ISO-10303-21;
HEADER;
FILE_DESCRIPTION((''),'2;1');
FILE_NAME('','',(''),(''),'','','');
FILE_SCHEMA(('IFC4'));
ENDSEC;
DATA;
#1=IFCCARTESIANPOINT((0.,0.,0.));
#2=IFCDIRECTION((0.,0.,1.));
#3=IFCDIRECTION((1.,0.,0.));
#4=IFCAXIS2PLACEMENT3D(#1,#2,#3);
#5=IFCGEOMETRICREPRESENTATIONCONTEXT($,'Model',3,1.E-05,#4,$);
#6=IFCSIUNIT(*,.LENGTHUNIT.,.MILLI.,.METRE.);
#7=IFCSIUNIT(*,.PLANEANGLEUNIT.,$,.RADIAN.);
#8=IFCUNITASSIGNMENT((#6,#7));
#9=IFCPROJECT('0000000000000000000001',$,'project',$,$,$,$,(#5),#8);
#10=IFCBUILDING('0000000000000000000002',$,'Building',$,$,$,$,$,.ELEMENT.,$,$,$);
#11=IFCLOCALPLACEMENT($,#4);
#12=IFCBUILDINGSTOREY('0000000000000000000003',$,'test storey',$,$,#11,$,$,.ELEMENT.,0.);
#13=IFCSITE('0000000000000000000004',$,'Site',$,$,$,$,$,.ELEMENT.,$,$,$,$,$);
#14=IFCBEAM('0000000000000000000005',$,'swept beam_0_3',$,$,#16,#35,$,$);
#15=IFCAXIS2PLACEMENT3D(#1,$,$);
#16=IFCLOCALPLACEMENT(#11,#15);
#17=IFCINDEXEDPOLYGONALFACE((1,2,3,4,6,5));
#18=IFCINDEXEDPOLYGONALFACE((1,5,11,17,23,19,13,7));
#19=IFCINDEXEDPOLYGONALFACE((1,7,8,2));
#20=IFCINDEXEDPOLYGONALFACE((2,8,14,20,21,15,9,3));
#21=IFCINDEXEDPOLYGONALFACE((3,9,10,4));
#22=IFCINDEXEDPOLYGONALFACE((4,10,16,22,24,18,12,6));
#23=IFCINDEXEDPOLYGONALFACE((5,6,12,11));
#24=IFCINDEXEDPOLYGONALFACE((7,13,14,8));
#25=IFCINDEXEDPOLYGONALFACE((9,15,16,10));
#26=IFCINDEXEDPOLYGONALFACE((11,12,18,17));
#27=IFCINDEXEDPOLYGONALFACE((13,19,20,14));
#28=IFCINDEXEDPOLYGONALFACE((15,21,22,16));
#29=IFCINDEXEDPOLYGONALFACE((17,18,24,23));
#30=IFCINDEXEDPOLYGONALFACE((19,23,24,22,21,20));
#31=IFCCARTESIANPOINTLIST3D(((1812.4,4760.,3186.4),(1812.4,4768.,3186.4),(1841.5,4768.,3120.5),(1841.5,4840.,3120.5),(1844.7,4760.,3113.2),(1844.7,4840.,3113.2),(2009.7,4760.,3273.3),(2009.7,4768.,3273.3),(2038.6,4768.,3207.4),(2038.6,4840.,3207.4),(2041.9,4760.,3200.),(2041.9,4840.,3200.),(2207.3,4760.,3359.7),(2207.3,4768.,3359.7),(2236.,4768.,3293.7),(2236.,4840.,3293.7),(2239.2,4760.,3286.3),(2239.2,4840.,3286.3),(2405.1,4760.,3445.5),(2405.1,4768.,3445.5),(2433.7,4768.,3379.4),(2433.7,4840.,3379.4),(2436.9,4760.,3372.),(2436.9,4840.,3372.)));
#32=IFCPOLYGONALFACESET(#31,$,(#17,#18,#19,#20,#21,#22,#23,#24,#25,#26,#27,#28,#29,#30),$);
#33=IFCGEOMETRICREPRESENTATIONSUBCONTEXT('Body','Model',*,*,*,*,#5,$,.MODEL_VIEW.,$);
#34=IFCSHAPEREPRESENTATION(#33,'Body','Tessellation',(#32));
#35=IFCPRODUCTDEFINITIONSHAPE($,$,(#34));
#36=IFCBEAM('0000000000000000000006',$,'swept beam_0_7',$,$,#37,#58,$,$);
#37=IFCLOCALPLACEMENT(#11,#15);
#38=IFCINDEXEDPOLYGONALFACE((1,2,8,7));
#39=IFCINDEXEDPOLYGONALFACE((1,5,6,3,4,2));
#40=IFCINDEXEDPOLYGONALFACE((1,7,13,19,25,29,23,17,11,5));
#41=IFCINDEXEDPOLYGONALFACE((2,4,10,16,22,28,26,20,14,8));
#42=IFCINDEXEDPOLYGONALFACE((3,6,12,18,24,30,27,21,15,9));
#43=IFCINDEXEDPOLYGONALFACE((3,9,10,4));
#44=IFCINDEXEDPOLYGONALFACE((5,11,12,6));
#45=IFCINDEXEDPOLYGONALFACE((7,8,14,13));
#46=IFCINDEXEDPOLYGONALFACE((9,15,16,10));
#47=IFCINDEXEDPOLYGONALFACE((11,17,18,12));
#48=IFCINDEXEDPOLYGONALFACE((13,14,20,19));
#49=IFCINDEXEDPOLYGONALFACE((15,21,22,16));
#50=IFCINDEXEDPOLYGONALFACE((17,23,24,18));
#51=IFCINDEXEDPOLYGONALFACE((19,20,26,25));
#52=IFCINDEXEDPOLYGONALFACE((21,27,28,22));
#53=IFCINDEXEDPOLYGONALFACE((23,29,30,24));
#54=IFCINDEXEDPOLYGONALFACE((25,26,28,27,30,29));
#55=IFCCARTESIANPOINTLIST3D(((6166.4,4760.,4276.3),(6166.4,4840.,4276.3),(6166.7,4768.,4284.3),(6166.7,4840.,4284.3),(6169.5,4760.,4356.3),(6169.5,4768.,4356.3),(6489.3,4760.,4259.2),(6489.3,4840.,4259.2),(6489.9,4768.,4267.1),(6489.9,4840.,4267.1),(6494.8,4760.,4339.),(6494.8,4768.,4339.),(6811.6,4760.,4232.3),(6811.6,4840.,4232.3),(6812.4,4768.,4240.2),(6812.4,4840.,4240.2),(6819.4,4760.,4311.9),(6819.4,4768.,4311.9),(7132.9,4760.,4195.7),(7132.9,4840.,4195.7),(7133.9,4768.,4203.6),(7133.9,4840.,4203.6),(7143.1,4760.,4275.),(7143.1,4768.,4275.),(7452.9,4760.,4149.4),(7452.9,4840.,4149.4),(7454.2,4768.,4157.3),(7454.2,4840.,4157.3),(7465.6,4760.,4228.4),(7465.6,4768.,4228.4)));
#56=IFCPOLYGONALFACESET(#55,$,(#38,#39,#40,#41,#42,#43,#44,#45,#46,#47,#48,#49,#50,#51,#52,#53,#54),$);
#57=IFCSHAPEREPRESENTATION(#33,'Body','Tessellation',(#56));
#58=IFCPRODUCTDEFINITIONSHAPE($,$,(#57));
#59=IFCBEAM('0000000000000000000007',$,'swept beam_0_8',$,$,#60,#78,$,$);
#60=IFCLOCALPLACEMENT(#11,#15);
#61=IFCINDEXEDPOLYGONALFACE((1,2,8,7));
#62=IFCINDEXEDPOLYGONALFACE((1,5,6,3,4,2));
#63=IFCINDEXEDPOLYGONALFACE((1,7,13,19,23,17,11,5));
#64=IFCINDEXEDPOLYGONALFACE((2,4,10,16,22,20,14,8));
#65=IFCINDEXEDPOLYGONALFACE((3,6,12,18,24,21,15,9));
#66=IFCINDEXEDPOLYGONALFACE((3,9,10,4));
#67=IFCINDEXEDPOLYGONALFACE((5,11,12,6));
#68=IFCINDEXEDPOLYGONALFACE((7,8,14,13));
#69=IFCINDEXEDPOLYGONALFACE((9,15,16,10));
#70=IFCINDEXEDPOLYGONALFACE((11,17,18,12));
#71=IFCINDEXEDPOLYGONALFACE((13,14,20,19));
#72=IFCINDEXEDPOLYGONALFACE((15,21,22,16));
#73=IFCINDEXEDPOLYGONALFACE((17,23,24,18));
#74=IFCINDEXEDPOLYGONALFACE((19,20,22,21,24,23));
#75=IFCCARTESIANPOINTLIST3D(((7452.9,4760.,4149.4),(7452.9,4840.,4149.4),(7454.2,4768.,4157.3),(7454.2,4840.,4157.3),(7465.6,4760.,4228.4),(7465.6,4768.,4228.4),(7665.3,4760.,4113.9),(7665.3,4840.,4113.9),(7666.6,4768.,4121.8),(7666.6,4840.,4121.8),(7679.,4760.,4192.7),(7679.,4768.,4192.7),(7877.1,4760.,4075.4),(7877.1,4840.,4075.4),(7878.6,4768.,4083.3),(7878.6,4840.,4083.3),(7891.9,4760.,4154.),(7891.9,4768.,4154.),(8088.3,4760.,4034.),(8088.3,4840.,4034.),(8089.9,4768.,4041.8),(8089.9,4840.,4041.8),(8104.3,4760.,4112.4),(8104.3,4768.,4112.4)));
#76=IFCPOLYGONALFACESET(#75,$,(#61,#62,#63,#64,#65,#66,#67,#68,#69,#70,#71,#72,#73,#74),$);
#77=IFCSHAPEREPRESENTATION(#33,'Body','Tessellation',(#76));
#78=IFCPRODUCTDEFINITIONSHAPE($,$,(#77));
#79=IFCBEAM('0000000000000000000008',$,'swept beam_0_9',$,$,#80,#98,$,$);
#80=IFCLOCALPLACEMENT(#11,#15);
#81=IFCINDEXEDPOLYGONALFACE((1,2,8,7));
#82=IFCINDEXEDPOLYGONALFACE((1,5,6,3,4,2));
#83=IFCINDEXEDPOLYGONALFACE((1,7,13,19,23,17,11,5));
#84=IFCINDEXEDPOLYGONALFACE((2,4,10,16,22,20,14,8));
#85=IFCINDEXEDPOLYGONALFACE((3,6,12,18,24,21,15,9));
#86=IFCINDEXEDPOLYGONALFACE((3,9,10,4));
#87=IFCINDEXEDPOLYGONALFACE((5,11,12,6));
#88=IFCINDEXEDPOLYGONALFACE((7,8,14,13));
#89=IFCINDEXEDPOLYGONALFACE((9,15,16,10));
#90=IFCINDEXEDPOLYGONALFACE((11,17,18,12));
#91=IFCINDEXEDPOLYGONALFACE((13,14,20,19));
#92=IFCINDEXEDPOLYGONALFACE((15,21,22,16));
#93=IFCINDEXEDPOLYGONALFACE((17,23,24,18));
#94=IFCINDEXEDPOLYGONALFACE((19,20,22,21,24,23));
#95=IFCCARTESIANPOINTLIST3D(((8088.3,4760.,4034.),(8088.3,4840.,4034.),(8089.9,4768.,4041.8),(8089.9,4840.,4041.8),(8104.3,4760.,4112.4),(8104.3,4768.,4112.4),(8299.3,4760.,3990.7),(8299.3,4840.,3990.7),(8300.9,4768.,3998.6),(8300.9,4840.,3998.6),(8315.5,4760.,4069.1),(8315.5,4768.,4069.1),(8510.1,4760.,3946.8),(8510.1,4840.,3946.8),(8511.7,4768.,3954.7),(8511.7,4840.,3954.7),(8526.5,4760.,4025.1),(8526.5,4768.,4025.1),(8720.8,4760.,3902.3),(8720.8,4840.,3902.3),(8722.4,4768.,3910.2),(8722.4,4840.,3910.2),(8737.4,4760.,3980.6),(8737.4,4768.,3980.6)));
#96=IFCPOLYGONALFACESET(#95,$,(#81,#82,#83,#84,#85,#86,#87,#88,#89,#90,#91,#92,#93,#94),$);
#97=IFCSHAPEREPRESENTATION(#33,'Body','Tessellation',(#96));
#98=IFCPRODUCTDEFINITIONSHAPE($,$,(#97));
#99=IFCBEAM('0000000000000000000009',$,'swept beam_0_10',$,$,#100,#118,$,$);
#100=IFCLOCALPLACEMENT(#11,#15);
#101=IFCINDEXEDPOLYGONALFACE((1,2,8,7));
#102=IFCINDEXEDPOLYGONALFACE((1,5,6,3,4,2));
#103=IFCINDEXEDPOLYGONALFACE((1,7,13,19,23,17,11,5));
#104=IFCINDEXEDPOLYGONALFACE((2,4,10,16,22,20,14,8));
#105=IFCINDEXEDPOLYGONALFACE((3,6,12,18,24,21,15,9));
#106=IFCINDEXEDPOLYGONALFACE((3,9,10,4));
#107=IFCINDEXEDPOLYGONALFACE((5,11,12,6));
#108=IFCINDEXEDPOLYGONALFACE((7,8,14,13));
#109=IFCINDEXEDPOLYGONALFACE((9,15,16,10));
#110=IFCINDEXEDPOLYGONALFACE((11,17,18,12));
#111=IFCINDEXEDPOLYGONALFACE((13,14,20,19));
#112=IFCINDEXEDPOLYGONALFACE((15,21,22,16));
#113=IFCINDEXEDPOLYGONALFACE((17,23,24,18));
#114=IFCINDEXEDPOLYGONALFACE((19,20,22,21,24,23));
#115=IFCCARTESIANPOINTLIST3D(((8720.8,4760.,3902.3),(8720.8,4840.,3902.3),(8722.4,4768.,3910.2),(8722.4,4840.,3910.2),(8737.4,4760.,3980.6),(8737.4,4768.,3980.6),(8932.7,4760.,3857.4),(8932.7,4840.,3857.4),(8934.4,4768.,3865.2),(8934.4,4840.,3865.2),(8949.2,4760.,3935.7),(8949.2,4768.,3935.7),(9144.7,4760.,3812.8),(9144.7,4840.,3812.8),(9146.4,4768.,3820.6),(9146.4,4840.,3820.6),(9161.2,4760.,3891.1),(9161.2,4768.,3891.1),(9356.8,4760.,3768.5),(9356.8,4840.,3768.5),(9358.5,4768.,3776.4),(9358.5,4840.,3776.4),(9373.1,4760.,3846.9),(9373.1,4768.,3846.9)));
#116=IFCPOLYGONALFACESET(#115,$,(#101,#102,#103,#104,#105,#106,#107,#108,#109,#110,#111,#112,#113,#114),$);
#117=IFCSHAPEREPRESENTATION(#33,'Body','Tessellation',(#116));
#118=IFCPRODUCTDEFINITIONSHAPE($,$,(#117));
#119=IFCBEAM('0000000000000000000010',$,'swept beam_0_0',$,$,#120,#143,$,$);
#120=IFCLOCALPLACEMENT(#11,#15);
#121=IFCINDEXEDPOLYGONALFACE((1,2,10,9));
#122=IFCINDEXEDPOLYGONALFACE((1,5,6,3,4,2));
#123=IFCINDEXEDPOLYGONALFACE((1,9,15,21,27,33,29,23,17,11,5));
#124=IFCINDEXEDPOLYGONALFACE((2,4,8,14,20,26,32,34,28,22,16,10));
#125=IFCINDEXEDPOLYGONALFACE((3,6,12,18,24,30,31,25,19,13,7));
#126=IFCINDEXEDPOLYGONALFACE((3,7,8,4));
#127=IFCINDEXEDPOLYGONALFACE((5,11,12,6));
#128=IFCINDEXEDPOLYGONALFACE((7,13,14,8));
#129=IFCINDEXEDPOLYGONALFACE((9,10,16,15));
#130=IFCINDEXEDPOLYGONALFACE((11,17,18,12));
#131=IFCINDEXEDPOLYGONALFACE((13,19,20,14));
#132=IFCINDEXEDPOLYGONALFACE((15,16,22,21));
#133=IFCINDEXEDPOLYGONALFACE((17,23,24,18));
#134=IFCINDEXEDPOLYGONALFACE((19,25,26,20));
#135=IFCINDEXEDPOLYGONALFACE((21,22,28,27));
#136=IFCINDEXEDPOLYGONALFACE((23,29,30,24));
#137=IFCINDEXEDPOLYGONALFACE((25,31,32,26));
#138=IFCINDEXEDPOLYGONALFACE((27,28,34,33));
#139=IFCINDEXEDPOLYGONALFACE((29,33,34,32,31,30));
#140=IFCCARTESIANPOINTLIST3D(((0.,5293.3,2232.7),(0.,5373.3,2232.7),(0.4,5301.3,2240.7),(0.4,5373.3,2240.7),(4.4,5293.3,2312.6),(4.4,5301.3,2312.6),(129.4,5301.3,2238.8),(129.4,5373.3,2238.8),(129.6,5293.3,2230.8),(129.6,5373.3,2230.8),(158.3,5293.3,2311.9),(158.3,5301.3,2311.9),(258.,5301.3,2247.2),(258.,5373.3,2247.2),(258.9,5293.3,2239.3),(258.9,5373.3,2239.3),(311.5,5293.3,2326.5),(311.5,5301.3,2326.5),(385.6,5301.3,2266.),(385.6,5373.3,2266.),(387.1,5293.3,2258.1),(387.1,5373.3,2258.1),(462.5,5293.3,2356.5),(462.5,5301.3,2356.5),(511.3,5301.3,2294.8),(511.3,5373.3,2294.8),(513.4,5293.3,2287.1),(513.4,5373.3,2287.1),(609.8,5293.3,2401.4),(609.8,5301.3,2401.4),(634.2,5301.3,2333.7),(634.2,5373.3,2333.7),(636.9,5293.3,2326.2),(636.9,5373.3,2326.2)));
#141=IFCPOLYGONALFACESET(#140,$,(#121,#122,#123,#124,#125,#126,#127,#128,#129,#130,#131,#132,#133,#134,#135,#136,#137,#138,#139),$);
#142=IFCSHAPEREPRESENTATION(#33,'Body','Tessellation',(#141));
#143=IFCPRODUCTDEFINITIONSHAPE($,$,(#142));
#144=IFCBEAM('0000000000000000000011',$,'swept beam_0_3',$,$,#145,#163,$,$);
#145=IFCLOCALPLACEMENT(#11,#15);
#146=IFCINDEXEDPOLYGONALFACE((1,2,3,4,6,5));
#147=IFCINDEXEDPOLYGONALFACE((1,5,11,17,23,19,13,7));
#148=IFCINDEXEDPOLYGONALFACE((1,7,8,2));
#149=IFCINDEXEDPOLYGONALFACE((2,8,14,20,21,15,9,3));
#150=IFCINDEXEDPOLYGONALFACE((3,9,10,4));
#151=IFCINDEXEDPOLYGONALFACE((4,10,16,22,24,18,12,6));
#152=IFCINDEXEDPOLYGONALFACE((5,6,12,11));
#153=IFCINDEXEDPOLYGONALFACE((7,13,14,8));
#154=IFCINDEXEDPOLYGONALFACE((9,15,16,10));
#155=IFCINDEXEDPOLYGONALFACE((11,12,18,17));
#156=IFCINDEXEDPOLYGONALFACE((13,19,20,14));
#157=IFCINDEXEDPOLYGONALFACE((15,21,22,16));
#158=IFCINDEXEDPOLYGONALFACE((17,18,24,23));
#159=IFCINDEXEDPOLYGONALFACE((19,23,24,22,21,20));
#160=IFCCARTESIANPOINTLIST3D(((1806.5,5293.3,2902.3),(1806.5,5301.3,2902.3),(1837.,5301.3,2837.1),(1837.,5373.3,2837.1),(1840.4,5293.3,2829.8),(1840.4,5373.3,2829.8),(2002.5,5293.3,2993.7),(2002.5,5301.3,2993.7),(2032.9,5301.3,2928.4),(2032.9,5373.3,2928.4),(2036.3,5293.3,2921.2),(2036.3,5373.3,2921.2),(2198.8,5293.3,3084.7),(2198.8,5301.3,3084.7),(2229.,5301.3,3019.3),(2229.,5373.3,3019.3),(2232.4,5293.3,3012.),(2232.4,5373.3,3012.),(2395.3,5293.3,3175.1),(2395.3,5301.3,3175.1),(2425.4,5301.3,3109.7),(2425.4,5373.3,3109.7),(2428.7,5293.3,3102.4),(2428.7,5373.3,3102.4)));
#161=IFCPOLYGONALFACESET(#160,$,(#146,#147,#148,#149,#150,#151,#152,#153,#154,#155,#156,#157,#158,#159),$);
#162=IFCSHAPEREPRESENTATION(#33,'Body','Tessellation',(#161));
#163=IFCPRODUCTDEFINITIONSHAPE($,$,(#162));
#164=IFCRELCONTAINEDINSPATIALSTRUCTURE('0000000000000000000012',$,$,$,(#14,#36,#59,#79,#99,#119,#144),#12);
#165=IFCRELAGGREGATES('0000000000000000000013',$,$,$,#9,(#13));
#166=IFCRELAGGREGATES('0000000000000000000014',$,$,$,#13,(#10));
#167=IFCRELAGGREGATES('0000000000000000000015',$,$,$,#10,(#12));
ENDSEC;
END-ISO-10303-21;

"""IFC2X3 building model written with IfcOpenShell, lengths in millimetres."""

from ifc_helpers import new_model, entity, si_unit, origin_with_axes, place, context, subcontext, project, spatial, element, save


model = new_model("IFC2X3")

# Units and contexts
model_context = context("Model", 3, precision=1e-05, world=origin_with_axes())
body_context = subcontext(model_context, "Body", "Model", "MODEL_VIEW")
ifc_project = project(units=[si_unit("LENGTHUNIT", "METRE", prefix="MILLI"), si_unit("PLANEANGLEUNIT", "RADIAN")], contexts=[model_context])

# Site, building, storey
site = spatial("IfcSite", under=ifc_project, Name="Site", CompositionType="ELEMENT")
building = spatial("IfcBuilding", under=site, Name="Building", CompositionType="ELEMENT")
storey_placement = place(None, origin_with_axes())
storey = spatial("IfcBuildingStorey", under=building, at=storey_placement, Name="test storey", CompositionType="ELEMENT", Elevation=0.0)

# Beams
beam_1_placement = place(storey_placement, origin_with_axes())
element("IfcBeam", 1, at=beam_1_placement, inside=storey, Name="swept beam_0_3", context=body_context, shape_type="SweptSolid", body=[
    entity("IfcRevolvedAreaSolid", entity("IfcArbitraryClosedProfileDef", "AREA", None, entity("IfcPolyline", [entity("IfcCartesianPoint", [80.0, -40.0]), entity("IfcCartesianPoint", [80.0, -32.0]), entity("IfcCartesianPoint", [8.0, -32.0]), entity("IfcCartesianPoint", [8.0, 40.0]), entity("IfcCartesianPoint", [0.0, 40.0]), entity("IfcCartesianPoint", [0.0, -40.0]), entity("IfcCartesianPoint", [80.0, -40.0])])), entity("IfcAxis2Placement3D", entity("IfcCartesianPoint", [1844.7, 4800.0, 3113.2]), entity("IfcDirection", [-0.9145, 0.0, -0.4045]), entity("IfcDirection", [-0.4045, 0.0, 0.9145])), entity("IfcAxis1Placement", entity("IfcCartesianPoint", [-74672.2, 0.0, 0.0]), entity("IfcDirection", [0.0, 1.0, 0.0])), 0.008654),
])
beam_2_placement = place(storey_placement, origin_with_axes())
element("IfcBeam", 2, at=beam_2_placement, inside=storey, Name="swept beam_0_7", context=body_context, shape_type="SweptSolid", body=[
    entity("IfcRevolvedAreaSolid", entity("IfcArbitraryClosedProfileDef", "AREA", None, entity("IfcPolyline", [entity("IfcCartesianPoint", [80.0, -40.0]), entity("IfcCartesianPoint", [80.0, -32.0]), entity("IfcCartesianPoint", [8.0, -32.0]), entity("IfcCartesianPoint", [8.0, 40.0]), entity("IfcCartesianPoint", [0.0, 40.0]), entity("IfcCartesianPoint", [0.0, -40.0]), entity("IfcCartesianPoint", [80.0, -40.0])])), entity("IfcAxis2Placement3D", entity("IfcCartesianPoint", [6166.4, 4800.0, 4276.3]), entity("IfcDirection", [-0.9993, 0.0, 0.038]), entity("IfcDirection", [0.038, 0.0, 0.9993])), entity("IfcAxis1Placement", entity("IfcCartesianPoint", [-10718.8, 0.0, 0.0]), entity("IfcDirection", [0.0, 1.0, 0.0])), 0.120679),
])
beam_3_placement = place(storey_placement, origin_with_axes())
element("IfcBeam", 3, at=beam_3_placement, inside=storey, Name="swept beam_0_8", context=body_context, shape_type="SweptSolid", body=[
    entity("IfcRevolvedAreaSolid", entity("IfcArbitraryClosedProfileDef", "AREA", None, entity("IfcPolyline", [entity("IfcCartesianPoint", [80.0, -40.0]), entity("IfcCartesianPoint", [80.0, -32.0]), entity("IfcCartesianPoint", [8.0, -32.0]), entity("IfcCartesianPoint", [8.0, 40.0]), entity("IfcCartesianPoint", [0.0, 40.0]), entity("IfcCartesianPoint", [0.0, -40.0]), entity("IfcCartesianPoint", [80.0, -40.0])])), entity("IfcAxis2Placement3D", entity("IfcCartesianPoint", [7452.9, 4800.0, 4149.4]), entity("IfcDirection", [-0.9874, 0.0, 0.158]), entity("IfcDirection", [0.158, 0.0, 0.9874])), entity("IfcAxis1Placement", entity("IfcCartesianPoint", [-15353.8, 0.0, 0.0]), entity("IfcDirection", [0.0, 1.0, 0.0])), 0.042066),
])
beam_4_placement = place(storey_placement, origin_with_axes())
element("IfcBeam", 4, at=beam_4_placement, inside=storey, Name="swept beam_0_9", context=body_context, shape_type="SweptSolid", body=[
    entity("IfcRevolvedAreaSolid", entity("IfcArbitraryClosedProfileDef", "AREA", None, entity("IfcPolyline", [entity("IfcCartesianPoint", [80.0, -40.0]), entity("IfcCartesianPoint", [80.0, -32.0]), entity("IfcCartesianPoint", [8.0, -32.0]), entity("IfcCartesianPoint", [8.0, 40.0]), entity("IfcCartesianPoint", [0.0, 40.0]), entity("IfcCartesianPoint", [0.0, -40.0]), entity("IfcCartesianPoint", [80.0, -40.0])])), entity("IfcAxis2Placement3D", entity("IfcCartesianPoint", [8088.3, 4800.0, 4034.0]), entity("IfcDirection", [-0.9799, 0.0, 0.1994]), entity("IfcDirection", [0.1994, 0.0, 0.9799])), entity("IfcAxis1Placement", entity("IfcCartesianPoint", [-72247.5, 0.0, 0.0]), entity("IfcDirection", [0.0, 1.0, 0.0])), 0.008941),
])
beam_5_placement = place(storey_placement, origin_with_axes())
element("IfcBeam", 5, at=beam_5_placement, inside=storey, Name="swept beam_0_10", context=body_context, shape_type="SweptSolid", body=[
    entity("IfcRevolvedAreaSolid", entity("IfcArbitraryClosedProfileDef", "AREA", None, entity("IfcPolyline", [entity("IfcCartesianPoint", [-80.0, 40.0]), entity("IfcCartesianPoint", [-80.0, 32.0]), entity("IfcCartesianPoint", [-8.0, 32.0]), entity("IfcCartesianPoint", [-8.0, -40.0]), entity("IfcCartesianPoint", [0.0, -40.0]), entity("IfcCartesianPoint", [0.0, 40.0]), entity("IfcCartesianPoint", [-80.0, 40.0])])), entity("IfcAxis2Placement3D", entity("IfcCartesianPoint", [8720.8, 4800.0, 3902.3]), entity("IfcDirection", [-0.9781, 0.0, 0.2081]), entity("IfcDirection", [-0.2081, 0.0, -0.9781])), entity("IfcAxis1Placement", entity("IfcCartesianPoint", [-142268.9, 0.0, 0.0]), entity("IfcDirection", [0.0, 1.0, 0.0])), 0.004569),
])
beam_6_placement = place(storey_placement, origin_with_axes())
element("IfcBeam", 6, at=beam_6_placement, inside=storey, Name="swept beam_0_0", context=body_context, shape_type="SweptSolid", body=[
    entity("IfcRevolvedAreaSolid", entity("IfcArbitraryClosedProfileDef", "AREA", None, entity("IfcPolyline", [entity("IfcCartesianPoint", [-80.0, 40.0]), entity("IfcCartesianPoint", [-80.0, 32.0]), entity("IfcCartesianPoint", [-8.0, 32.0]), entity("IfcCartesianPoint", [-8.0, -40.0]), entity("IfcCartesianPoint", [0.0, -40.0]), entity("IfcCartesianPoint", [0.0, 40.0]), entity("IfcCartesianPoint", [-80.0, 40.0])])), entity("IfcAxis2Placement3D", entity("IfcCartesianPoint", [0.0, 5333.3, 2232.7]), entity("IfcDirection", [-0.9985, 0.0, 0.0548]), entity("IfcDirection", [-0.0548, 0.0, -0.9985])), entity("IfcAxis1Placement", entity("IfcCartesianPoint", [-1615.5, 0.0, 0.0]), entity("IfcDirection", [0.0, 1.0, 0.0])), 0.401157),
])
beam_7_placement = place(storey_placement, origin_with_axes())
element("IfcBeam", 7, at=beam_7_placement, inside=storey, Name="swept beam_0_3", context=body_context, shape_type="SweptSolid", body=[
    entity("IfcRevolvedAreaSolid", entity("IfcArbitraryClosedProfileDef", "AREA", None, entity("IfcPolyline", [entity("IfcCartesianPoint", [80.0, -40.0]), entity("IfcCartesianPoint", [80.0, -32.0]), entity("IfcCartesianPoint", [8.0, -32.0]), entity("IfcCartesianPoint", [8.0, 40.0]), entity("IfcCartesianPoint", [0.0, 40.0]), entity("IfcCartesianPoint", [0.0, -40.0]), entity("IfcCartesianPoint", [80.0, -40.0])])), entity("IfcAxis2Placement3D", entity("IfcCartesianPoint", [1840.4, 5333.3, 2829.8]), entity("IfcDirection", [-0.9057, 0.0, -0.4239]), entity("IfcDirection", [-0.4239, 0.0, 0.9057])), entity("IfcAxis1Placement", entity("IfcCartesianPoint", [-84351.8, 0.0, 0.0]), entity("IfcDirection", [0.0, 1.0, 0.0])), 0.007687),
])

save(model, "model.ifc")
